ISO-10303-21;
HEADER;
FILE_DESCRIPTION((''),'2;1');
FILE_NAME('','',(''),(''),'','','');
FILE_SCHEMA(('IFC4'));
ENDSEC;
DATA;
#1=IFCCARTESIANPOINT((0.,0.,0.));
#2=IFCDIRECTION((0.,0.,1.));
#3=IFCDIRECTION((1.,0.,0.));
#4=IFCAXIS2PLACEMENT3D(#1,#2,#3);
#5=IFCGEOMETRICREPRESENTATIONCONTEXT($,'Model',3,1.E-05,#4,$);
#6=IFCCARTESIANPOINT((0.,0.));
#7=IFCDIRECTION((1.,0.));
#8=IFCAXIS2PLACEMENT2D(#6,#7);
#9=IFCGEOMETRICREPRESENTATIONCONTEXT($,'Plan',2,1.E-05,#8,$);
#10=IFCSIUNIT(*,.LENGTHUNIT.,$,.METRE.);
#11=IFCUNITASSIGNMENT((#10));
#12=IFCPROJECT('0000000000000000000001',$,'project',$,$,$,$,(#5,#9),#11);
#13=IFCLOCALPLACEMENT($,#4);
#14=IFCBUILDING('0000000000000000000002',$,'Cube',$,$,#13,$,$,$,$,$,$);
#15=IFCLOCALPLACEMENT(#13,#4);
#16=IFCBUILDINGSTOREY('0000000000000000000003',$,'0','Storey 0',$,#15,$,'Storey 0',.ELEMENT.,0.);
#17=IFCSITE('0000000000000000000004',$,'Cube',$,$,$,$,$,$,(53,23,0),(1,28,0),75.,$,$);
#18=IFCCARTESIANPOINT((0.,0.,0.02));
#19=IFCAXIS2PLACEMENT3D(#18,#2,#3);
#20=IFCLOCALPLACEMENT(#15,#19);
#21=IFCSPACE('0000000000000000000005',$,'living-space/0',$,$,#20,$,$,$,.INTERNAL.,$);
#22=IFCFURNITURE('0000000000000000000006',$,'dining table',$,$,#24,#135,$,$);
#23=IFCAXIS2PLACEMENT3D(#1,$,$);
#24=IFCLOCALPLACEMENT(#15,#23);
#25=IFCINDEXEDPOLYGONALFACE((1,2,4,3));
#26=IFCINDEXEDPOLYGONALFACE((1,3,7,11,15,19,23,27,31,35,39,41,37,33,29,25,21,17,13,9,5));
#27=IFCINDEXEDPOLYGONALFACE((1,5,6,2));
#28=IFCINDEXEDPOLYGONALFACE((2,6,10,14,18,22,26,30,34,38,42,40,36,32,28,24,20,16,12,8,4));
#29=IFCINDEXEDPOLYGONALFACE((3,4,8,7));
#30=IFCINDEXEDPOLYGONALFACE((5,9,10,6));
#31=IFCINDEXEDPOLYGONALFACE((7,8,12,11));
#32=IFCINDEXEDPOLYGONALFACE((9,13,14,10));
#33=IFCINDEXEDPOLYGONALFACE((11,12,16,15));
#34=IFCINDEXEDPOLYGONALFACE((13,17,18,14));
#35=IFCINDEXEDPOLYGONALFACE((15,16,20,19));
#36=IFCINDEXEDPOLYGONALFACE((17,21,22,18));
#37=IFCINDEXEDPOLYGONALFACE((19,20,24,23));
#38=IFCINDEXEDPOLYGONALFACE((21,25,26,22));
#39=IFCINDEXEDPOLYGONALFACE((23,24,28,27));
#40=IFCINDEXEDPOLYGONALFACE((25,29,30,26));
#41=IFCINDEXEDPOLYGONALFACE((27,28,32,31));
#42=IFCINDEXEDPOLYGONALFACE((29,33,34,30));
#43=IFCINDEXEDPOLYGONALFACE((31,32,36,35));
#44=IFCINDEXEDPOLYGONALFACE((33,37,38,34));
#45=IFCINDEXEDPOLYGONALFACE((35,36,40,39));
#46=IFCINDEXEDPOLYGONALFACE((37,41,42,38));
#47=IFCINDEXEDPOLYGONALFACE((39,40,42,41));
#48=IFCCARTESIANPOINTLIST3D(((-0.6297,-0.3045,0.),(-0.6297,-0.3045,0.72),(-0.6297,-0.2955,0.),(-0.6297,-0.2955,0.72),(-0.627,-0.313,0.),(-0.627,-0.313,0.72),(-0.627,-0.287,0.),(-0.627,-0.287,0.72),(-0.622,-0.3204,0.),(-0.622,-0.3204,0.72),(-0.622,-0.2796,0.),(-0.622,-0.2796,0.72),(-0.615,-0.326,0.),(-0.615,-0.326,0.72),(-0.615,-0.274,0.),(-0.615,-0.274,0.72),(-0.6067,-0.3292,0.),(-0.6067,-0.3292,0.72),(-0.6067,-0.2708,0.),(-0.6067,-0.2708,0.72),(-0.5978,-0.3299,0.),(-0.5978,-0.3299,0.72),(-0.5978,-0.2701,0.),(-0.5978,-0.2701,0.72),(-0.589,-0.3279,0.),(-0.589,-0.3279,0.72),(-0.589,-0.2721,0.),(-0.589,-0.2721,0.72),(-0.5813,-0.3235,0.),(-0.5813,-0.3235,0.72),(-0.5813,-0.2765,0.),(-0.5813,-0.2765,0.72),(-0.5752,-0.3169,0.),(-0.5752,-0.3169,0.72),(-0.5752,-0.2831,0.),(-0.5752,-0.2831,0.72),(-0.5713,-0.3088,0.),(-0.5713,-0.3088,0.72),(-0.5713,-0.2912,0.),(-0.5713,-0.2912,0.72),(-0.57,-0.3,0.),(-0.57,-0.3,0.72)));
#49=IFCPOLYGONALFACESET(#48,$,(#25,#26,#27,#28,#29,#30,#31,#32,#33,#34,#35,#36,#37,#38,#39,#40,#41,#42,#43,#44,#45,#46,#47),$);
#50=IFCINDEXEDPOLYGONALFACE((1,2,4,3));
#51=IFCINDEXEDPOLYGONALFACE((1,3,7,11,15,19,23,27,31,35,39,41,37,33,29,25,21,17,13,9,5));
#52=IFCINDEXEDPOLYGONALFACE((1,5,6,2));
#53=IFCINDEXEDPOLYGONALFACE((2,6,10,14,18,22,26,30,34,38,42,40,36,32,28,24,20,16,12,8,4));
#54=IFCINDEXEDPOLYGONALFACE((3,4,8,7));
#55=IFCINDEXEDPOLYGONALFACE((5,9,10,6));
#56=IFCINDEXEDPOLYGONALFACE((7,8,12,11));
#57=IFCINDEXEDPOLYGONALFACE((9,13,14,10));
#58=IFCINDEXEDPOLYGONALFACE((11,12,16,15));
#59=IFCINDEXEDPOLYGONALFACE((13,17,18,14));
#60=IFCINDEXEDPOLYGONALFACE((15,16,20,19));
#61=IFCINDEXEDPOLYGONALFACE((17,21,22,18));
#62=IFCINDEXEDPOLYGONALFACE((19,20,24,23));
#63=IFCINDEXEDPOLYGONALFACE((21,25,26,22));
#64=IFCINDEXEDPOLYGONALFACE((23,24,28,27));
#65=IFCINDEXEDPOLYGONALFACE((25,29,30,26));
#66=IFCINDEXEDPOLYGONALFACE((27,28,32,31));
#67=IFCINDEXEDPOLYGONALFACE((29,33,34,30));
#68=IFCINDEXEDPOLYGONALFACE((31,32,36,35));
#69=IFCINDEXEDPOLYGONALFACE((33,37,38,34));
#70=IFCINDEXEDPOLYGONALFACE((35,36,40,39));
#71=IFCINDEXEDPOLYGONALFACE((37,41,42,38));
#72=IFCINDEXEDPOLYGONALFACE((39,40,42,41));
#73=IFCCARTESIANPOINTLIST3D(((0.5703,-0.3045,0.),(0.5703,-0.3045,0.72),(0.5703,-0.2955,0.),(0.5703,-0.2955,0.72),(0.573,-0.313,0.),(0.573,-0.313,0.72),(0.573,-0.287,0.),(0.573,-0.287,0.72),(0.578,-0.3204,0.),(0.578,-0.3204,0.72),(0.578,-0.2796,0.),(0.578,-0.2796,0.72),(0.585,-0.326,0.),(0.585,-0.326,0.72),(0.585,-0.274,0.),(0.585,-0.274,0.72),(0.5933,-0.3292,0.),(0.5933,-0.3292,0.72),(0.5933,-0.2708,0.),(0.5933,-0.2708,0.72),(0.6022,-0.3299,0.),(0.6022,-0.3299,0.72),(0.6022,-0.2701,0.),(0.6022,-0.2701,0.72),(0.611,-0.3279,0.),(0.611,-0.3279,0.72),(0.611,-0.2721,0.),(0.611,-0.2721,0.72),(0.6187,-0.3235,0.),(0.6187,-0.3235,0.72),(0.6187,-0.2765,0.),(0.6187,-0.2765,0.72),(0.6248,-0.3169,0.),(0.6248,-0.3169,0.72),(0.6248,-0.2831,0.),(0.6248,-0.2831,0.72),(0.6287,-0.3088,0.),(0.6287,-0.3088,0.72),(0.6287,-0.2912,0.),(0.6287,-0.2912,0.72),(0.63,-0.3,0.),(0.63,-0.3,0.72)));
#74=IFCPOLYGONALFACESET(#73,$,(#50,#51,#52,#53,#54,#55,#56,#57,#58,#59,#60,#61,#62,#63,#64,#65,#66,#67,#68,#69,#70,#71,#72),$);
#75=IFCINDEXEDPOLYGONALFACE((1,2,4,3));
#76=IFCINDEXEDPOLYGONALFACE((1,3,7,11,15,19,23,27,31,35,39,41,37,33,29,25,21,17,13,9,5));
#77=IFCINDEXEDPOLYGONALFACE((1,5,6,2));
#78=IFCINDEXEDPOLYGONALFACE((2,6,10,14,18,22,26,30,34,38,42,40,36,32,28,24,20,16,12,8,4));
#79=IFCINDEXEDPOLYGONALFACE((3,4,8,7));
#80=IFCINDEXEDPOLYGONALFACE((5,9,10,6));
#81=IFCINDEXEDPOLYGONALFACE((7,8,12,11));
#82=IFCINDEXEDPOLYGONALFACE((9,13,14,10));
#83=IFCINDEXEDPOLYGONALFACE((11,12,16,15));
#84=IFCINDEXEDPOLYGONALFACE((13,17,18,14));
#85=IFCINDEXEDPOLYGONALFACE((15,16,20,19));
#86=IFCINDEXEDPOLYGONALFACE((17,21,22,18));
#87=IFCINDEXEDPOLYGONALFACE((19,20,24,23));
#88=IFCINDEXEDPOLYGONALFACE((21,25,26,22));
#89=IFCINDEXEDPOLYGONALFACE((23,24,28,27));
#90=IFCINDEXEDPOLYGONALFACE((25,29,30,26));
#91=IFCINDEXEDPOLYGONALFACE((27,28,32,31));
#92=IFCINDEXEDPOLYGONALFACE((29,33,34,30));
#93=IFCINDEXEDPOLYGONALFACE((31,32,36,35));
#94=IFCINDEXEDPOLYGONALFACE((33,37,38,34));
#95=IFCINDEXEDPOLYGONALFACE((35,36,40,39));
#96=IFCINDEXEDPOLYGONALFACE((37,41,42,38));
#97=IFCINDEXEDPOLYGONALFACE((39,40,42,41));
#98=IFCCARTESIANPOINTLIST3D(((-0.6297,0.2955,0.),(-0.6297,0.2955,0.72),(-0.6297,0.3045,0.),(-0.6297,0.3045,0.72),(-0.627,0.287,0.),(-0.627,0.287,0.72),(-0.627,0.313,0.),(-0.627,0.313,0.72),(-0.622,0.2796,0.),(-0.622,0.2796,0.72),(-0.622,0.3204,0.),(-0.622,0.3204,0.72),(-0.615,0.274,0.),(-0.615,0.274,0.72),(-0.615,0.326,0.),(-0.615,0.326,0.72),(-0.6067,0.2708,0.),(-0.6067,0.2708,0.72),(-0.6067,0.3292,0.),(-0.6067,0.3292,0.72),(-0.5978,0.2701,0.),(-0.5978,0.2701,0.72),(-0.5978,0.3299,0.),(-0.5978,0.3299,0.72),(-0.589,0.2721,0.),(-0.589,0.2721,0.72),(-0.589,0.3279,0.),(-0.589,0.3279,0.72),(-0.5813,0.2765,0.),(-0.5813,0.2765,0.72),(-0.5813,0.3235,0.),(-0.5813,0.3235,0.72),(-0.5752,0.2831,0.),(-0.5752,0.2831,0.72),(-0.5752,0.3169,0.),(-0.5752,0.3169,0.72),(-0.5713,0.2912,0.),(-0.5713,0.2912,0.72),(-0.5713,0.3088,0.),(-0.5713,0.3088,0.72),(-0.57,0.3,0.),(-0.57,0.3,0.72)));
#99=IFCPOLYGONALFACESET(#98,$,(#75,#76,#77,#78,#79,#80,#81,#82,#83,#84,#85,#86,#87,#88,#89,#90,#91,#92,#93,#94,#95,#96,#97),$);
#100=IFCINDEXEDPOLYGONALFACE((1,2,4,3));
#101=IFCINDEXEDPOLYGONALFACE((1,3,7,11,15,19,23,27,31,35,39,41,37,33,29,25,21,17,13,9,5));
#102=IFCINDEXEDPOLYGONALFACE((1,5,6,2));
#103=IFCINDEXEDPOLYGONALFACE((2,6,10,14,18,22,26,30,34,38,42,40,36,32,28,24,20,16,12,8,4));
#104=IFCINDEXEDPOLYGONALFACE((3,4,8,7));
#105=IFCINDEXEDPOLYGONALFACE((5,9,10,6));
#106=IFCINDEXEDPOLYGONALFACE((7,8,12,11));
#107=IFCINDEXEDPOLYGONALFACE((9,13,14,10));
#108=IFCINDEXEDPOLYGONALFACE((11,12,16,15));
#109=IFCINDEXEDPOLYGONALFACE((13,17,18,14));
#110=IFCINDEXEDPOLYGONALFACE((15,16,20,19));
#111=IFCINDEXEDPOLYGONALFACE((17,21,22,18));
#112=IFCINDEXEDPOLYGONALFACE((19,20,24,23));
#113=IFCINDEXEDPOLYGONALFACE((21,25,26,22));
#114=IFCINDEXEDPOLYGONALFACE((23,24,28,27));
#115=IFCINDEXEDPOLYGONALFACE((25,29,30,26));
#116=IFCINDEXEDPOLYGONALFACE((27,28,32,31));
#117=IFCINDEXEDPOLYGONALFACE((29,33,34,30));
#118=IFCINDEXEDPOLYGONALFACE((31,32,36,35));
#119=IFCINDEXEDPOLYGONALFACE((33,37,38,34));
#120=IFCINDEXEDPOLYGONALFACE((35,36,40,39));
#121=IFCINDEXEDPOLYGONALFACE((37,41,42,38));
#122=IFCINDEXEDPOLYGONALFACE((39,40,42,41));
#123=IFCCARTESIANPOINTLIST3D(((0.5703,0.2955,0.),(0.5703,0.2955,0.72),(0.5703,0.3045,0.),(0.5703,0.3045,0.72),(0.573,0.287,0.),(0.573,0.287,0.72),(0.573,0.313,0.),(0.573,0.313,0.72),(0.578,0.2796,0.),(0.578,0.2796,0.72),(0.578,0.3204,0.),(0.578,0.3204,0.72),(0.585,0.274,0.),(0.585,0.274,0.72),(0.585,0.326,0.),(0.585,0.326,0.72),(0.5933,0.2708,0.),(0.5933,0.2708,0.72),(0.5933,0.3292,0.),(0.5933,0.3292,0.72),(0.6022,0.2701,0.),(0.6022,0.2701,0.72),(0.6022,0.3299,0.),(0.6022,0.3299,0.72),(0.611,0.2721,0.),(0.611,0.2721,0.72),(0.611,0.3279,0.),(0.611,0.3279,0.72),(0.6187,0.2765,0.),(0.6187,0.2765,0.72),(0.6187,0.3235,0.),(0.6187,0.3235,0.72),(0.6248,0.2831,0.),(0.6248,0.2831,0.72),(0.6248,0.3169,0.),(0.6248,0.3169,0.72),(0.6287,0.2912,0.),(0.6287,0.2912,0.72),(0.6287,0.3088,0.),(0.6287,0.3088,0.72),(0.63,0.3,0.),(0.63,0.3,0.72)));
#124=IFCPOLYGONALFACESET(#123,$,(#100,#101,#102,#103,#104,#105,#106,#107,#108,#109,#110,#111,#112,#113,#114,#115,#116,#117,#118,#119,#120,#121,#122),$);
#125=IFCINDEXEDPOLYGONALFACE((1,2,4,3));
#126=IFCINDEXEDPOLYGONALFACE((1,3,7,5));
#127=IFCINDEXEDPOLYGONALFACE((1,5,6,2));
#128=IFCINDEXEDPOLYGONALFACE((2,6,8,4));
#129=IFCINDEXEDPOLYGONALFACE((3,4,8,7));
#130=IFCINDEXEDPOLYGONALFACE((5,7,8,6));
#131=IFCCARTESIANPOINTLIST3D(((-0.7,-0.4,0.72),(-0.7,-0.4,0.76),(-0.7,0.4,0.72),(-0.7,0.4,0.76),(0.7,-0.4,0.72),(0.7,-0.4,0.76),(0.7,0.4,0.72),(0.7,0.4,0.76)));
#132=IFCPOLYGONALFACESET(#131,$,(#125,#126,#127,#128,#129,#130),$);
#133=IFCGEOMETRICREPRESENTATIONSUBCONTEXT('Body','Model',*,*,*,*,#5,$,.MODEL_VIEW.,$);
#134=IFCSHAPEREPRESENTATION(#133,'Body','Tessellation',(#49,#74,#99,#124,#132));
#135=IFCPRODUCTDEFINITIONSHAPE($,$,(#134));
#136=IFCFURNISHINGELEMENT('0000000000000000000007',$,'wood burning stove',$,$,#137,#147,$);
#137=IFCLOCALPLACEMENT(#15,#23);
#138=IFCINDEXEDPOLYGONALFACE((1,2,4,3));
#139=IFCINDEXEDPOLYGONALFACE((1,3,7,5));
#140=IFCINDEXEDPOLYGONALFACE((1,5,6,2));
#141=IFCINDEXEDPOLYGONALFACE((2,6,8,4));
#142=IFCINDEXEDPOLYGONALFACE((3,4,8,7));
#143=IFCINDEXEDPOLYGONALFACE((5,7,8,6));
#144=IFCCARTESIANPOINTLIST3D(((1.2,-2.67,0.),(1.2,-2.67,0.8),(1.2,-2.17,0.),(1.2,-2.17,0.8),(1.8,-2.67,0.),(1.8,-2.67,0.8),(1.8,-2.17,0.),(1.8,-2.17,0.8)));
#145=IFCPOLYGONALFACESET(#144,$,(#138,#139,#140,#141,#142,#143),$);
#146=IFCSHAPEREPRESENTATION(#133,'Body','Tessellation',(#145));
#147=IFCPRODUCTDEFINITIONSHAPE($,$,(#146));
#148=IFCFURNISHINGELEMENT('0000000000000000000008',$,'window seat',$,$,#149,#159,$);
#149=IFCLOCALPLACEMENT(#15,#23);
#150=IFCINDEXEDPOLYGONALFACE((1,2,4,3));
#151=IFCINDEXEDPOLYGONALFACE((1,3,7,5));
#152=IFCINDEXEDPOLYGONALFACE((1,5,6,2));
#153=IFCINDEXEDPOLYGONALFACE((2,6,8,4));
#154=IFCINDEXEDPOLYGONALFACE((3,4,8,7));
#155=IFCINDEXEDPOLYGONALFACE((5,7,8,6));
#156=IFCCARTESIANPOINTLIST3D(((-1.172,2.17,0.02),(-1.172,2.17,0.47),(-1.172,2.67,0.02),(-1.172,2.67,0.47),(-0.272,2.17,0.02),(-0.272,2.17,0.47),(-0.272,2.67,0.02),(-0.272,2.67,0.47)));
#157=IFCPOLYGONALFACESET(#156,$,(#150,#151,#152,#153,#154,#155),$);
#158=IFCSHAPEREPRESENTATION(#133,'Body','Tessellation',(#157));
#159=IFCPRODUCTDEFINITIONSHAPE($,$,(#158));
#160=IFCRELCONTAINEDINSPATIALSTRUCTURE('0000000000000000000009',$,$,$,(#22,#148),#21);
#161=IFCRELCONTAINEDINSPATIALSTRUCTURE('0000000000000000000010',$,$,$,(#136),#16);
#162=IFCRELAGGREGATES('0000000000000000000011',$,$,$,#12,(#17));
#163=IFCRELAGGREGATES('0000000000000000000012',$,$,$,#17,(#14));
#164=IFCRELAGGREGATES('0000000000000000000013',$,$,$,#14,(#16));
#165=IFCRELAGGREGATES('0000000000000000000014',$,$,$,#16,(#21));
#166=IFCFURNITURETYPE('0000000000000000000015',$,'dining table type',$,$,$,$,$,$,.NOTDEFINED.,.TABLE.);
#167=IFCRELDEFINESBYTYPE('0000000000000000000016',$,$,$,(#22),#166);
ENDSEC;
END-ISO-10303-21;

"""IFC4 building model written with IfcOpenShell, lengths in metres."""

from ifc_helpers import new_model, entity, si_unit, frame, origin_with_axes, origin_2d_with_axis, place, context, subcontext, project, spatial, line, indexed_curve, outline, extrude, source, transform, mapped, type_object, type_shapes, element, save


model = new_model("IFC4")

# Units and contexts
model_context = context("Model", 3, precision=1e-05, world=origin_with_axes())
plan_context = context("Plan", 2, precision=1e-05, world=origin_2d_with_axis())
body_context = subcontext(model_context, "Body", "Model", "MODEL_VIEW")
ifc_project = project(units=[si_unit("LENGTHUNIT", "METRE")], contexts=[model_context, plan_context])

# Site, building, storey
site = spatial("IfcSite", under=ifc_project, Name="Cube", RefLatitude=(53, 23, 0), RefLongitude=(1, 28, 0), RefElevation=75.0)
building_placement = place(None, origin_with_axes())
building = spatial("IfcBuilding", under=site, at=building_placement, Name="Cube")
storey_placement = place(building_placement, origin_with_axes())
storey = spatial("IfcBuildingStorey", under=building, at=storey_placement, Name="0", Description="Storey 0", LongName="Storey 0", CompositionType="ELEMENT", Elevation=0.0)

# Shared definitions
space_placement = place(storey_placement, frame((0.0, 0.0, 0.02), z_axis=(0.0, 0.0, 1.0), x_axis=(1.0, 0.0, 0.0)))
space = spatial("IfcSpace", under=storey, at=space_placement, Name="living-space/0", PredefinedType="INTERNAL")

# Furniture
furniture_type = type_object("IfcFurnitureType", Name="dining table type", AssemblyPlace="NOTDEFINED", PredefinedType="TABLE")
shared_circle = entity("IfcCircle", entity("IfcAxis2Placement2D", entity("IfcCartesianPoint", [0.0, 0.0])), 0.03)
shared_shape_1 = source(origin_with_axes(), body_context, "Body", "SweptSolid", [
    entity("IfcExtrudedAreaSolid", entity("IfcArbitraryClosedProfileDef", "AREA", None, shared_circle), entity("IfcAxis2Placement3D", entity("IfcCartesianPoint", [-0.6, -0.3, 0.0]), entity("IfcDirection", [0.0, 0.0, 1.0]), entity("IfcDirection", [1.0, 0.0, 0.0])), entity("IfcDirection", [0.0, 0.0, 1.0]), 0.72),
    entity("IfcExtrudedAreaSolid", entity("IfcArbitraryClosedProfileDef", "AREA", None, shared_circle), entity("IfcAxis2Placement3D", entity("IfcCartesianPoint", [0.6, -0.3, 0.0]), entity("IfcDirection", [0.0, 0.0, 1.0]), entity("IfcDirection", [1.0, 0.0, 0.0])), entity("IfcDirection", [0.0, 0.0, 1.0]), 0.72),
    entity("IfcExtrudedAreaSolid", entity("IfcArbitraryClosedProfileDef", "AREA", None, shared_circle), entity("IfcAxis2Placement3D", entity("IfcCartesianPoint", [-0.6, 0.3, 0.0]), entity("IfcDirection", [0.0, 0.0, 1.0]), entity("IfcDirection", [1.0, 0.0, 0.0])), entity("IfcDirection", [0.0, 0.0, 1.0]), 0.72),
    entity("IfcExtrudedAreaSolid", entity("IfcArbitraryClosedProfileDef", "AREA", None, shared_circle), entity("IfcAxis2Placement3D", entity("IfcCartesianPoint", [0.6, 0.3, 0.0]), entity("IfcDirection", [0.0, 0.0, 1.0]), entity("IfcDirection", [1.0, 0.0, 0.0])), entity("IfcDirection", [0.0, 0.0, 1.0]), 0.72),
    extrude(outline(indexed_curve([(-0.7, -0.4), (0.7, -0.4), (0.7, 0.4), (-0.7, 0.4)], segments=[line(1, 2, 3, 4, 1)])), frame((0.0, 0.0, 0.72), z_axis=(0.0, 0.0, 1.0), x_axis=(1.0, 0.0, 0.0)), (0.0, 0.0, 1.0), 0.04),
])
type_shapes(furniture_type, [shared_shape_1])
furniture_placement = place(space_placement, frame((0.0, 0.0, -0.02), z_axis=(0.0, 0.0, 1.0), x_axis=(1.0, 0.0, 0.0)))
element("IfcFurniture", 1, at=furniture_placement, inside=space, type_object=furniture_type, Name="dining table", context=body_context, shape_type="MappedRepresentation", body=[
    mapped(shared_shape_1, transform((0.0, 0.0, 0.0), x_axis=(1.0, 0.0, 0.0), y_axis=(0.0, 1.0, 0.0), z_axis=(0.0, 0.0, 1.0), scale=1.0)),
])

# Furnishing elements
furnishing_1_placement = place(storey_placement, frame((1.2, -2.67, 0.0), z_axis=(0.0, 0.0, 1.0), x_axis=(1.0, 0.0, 0.0)))
element("IfcFurnishingElement", 2, at=furnishing_1_placement, inside=storey, Name="wood burning stove", context=body_context, shape_type="SweptSolid", body=[
    extrude(outline(indexed_curve([(0.0, 0.0), (0.6, 0.0), (0.6, 0.5), (0.0, 0.5)])), None, (0.0, 0.0, 1.0), 0.8),
])
furnishing_2_placement = place(space_placement, frame((-1.172, 2.17, 0.0), z_axis=(0.0, 0.0, 1.0), x_axis=(1.0, 0.0, 0.0)))
element("IfcFurnishingElement", 3, at=furnishing_2_placement, inside=space, Name="window seat", context=body_context, shape_type="SweptSolid", body=[
    extrude(outline(indexed_curve([(0.0, 0.0), (0.9, 0.0), (0.9, 0.5), (0.0, 0.5)])), None, (0.0, 0.0, 1.0), 0.45),
])

save(model, "model.ifc")
